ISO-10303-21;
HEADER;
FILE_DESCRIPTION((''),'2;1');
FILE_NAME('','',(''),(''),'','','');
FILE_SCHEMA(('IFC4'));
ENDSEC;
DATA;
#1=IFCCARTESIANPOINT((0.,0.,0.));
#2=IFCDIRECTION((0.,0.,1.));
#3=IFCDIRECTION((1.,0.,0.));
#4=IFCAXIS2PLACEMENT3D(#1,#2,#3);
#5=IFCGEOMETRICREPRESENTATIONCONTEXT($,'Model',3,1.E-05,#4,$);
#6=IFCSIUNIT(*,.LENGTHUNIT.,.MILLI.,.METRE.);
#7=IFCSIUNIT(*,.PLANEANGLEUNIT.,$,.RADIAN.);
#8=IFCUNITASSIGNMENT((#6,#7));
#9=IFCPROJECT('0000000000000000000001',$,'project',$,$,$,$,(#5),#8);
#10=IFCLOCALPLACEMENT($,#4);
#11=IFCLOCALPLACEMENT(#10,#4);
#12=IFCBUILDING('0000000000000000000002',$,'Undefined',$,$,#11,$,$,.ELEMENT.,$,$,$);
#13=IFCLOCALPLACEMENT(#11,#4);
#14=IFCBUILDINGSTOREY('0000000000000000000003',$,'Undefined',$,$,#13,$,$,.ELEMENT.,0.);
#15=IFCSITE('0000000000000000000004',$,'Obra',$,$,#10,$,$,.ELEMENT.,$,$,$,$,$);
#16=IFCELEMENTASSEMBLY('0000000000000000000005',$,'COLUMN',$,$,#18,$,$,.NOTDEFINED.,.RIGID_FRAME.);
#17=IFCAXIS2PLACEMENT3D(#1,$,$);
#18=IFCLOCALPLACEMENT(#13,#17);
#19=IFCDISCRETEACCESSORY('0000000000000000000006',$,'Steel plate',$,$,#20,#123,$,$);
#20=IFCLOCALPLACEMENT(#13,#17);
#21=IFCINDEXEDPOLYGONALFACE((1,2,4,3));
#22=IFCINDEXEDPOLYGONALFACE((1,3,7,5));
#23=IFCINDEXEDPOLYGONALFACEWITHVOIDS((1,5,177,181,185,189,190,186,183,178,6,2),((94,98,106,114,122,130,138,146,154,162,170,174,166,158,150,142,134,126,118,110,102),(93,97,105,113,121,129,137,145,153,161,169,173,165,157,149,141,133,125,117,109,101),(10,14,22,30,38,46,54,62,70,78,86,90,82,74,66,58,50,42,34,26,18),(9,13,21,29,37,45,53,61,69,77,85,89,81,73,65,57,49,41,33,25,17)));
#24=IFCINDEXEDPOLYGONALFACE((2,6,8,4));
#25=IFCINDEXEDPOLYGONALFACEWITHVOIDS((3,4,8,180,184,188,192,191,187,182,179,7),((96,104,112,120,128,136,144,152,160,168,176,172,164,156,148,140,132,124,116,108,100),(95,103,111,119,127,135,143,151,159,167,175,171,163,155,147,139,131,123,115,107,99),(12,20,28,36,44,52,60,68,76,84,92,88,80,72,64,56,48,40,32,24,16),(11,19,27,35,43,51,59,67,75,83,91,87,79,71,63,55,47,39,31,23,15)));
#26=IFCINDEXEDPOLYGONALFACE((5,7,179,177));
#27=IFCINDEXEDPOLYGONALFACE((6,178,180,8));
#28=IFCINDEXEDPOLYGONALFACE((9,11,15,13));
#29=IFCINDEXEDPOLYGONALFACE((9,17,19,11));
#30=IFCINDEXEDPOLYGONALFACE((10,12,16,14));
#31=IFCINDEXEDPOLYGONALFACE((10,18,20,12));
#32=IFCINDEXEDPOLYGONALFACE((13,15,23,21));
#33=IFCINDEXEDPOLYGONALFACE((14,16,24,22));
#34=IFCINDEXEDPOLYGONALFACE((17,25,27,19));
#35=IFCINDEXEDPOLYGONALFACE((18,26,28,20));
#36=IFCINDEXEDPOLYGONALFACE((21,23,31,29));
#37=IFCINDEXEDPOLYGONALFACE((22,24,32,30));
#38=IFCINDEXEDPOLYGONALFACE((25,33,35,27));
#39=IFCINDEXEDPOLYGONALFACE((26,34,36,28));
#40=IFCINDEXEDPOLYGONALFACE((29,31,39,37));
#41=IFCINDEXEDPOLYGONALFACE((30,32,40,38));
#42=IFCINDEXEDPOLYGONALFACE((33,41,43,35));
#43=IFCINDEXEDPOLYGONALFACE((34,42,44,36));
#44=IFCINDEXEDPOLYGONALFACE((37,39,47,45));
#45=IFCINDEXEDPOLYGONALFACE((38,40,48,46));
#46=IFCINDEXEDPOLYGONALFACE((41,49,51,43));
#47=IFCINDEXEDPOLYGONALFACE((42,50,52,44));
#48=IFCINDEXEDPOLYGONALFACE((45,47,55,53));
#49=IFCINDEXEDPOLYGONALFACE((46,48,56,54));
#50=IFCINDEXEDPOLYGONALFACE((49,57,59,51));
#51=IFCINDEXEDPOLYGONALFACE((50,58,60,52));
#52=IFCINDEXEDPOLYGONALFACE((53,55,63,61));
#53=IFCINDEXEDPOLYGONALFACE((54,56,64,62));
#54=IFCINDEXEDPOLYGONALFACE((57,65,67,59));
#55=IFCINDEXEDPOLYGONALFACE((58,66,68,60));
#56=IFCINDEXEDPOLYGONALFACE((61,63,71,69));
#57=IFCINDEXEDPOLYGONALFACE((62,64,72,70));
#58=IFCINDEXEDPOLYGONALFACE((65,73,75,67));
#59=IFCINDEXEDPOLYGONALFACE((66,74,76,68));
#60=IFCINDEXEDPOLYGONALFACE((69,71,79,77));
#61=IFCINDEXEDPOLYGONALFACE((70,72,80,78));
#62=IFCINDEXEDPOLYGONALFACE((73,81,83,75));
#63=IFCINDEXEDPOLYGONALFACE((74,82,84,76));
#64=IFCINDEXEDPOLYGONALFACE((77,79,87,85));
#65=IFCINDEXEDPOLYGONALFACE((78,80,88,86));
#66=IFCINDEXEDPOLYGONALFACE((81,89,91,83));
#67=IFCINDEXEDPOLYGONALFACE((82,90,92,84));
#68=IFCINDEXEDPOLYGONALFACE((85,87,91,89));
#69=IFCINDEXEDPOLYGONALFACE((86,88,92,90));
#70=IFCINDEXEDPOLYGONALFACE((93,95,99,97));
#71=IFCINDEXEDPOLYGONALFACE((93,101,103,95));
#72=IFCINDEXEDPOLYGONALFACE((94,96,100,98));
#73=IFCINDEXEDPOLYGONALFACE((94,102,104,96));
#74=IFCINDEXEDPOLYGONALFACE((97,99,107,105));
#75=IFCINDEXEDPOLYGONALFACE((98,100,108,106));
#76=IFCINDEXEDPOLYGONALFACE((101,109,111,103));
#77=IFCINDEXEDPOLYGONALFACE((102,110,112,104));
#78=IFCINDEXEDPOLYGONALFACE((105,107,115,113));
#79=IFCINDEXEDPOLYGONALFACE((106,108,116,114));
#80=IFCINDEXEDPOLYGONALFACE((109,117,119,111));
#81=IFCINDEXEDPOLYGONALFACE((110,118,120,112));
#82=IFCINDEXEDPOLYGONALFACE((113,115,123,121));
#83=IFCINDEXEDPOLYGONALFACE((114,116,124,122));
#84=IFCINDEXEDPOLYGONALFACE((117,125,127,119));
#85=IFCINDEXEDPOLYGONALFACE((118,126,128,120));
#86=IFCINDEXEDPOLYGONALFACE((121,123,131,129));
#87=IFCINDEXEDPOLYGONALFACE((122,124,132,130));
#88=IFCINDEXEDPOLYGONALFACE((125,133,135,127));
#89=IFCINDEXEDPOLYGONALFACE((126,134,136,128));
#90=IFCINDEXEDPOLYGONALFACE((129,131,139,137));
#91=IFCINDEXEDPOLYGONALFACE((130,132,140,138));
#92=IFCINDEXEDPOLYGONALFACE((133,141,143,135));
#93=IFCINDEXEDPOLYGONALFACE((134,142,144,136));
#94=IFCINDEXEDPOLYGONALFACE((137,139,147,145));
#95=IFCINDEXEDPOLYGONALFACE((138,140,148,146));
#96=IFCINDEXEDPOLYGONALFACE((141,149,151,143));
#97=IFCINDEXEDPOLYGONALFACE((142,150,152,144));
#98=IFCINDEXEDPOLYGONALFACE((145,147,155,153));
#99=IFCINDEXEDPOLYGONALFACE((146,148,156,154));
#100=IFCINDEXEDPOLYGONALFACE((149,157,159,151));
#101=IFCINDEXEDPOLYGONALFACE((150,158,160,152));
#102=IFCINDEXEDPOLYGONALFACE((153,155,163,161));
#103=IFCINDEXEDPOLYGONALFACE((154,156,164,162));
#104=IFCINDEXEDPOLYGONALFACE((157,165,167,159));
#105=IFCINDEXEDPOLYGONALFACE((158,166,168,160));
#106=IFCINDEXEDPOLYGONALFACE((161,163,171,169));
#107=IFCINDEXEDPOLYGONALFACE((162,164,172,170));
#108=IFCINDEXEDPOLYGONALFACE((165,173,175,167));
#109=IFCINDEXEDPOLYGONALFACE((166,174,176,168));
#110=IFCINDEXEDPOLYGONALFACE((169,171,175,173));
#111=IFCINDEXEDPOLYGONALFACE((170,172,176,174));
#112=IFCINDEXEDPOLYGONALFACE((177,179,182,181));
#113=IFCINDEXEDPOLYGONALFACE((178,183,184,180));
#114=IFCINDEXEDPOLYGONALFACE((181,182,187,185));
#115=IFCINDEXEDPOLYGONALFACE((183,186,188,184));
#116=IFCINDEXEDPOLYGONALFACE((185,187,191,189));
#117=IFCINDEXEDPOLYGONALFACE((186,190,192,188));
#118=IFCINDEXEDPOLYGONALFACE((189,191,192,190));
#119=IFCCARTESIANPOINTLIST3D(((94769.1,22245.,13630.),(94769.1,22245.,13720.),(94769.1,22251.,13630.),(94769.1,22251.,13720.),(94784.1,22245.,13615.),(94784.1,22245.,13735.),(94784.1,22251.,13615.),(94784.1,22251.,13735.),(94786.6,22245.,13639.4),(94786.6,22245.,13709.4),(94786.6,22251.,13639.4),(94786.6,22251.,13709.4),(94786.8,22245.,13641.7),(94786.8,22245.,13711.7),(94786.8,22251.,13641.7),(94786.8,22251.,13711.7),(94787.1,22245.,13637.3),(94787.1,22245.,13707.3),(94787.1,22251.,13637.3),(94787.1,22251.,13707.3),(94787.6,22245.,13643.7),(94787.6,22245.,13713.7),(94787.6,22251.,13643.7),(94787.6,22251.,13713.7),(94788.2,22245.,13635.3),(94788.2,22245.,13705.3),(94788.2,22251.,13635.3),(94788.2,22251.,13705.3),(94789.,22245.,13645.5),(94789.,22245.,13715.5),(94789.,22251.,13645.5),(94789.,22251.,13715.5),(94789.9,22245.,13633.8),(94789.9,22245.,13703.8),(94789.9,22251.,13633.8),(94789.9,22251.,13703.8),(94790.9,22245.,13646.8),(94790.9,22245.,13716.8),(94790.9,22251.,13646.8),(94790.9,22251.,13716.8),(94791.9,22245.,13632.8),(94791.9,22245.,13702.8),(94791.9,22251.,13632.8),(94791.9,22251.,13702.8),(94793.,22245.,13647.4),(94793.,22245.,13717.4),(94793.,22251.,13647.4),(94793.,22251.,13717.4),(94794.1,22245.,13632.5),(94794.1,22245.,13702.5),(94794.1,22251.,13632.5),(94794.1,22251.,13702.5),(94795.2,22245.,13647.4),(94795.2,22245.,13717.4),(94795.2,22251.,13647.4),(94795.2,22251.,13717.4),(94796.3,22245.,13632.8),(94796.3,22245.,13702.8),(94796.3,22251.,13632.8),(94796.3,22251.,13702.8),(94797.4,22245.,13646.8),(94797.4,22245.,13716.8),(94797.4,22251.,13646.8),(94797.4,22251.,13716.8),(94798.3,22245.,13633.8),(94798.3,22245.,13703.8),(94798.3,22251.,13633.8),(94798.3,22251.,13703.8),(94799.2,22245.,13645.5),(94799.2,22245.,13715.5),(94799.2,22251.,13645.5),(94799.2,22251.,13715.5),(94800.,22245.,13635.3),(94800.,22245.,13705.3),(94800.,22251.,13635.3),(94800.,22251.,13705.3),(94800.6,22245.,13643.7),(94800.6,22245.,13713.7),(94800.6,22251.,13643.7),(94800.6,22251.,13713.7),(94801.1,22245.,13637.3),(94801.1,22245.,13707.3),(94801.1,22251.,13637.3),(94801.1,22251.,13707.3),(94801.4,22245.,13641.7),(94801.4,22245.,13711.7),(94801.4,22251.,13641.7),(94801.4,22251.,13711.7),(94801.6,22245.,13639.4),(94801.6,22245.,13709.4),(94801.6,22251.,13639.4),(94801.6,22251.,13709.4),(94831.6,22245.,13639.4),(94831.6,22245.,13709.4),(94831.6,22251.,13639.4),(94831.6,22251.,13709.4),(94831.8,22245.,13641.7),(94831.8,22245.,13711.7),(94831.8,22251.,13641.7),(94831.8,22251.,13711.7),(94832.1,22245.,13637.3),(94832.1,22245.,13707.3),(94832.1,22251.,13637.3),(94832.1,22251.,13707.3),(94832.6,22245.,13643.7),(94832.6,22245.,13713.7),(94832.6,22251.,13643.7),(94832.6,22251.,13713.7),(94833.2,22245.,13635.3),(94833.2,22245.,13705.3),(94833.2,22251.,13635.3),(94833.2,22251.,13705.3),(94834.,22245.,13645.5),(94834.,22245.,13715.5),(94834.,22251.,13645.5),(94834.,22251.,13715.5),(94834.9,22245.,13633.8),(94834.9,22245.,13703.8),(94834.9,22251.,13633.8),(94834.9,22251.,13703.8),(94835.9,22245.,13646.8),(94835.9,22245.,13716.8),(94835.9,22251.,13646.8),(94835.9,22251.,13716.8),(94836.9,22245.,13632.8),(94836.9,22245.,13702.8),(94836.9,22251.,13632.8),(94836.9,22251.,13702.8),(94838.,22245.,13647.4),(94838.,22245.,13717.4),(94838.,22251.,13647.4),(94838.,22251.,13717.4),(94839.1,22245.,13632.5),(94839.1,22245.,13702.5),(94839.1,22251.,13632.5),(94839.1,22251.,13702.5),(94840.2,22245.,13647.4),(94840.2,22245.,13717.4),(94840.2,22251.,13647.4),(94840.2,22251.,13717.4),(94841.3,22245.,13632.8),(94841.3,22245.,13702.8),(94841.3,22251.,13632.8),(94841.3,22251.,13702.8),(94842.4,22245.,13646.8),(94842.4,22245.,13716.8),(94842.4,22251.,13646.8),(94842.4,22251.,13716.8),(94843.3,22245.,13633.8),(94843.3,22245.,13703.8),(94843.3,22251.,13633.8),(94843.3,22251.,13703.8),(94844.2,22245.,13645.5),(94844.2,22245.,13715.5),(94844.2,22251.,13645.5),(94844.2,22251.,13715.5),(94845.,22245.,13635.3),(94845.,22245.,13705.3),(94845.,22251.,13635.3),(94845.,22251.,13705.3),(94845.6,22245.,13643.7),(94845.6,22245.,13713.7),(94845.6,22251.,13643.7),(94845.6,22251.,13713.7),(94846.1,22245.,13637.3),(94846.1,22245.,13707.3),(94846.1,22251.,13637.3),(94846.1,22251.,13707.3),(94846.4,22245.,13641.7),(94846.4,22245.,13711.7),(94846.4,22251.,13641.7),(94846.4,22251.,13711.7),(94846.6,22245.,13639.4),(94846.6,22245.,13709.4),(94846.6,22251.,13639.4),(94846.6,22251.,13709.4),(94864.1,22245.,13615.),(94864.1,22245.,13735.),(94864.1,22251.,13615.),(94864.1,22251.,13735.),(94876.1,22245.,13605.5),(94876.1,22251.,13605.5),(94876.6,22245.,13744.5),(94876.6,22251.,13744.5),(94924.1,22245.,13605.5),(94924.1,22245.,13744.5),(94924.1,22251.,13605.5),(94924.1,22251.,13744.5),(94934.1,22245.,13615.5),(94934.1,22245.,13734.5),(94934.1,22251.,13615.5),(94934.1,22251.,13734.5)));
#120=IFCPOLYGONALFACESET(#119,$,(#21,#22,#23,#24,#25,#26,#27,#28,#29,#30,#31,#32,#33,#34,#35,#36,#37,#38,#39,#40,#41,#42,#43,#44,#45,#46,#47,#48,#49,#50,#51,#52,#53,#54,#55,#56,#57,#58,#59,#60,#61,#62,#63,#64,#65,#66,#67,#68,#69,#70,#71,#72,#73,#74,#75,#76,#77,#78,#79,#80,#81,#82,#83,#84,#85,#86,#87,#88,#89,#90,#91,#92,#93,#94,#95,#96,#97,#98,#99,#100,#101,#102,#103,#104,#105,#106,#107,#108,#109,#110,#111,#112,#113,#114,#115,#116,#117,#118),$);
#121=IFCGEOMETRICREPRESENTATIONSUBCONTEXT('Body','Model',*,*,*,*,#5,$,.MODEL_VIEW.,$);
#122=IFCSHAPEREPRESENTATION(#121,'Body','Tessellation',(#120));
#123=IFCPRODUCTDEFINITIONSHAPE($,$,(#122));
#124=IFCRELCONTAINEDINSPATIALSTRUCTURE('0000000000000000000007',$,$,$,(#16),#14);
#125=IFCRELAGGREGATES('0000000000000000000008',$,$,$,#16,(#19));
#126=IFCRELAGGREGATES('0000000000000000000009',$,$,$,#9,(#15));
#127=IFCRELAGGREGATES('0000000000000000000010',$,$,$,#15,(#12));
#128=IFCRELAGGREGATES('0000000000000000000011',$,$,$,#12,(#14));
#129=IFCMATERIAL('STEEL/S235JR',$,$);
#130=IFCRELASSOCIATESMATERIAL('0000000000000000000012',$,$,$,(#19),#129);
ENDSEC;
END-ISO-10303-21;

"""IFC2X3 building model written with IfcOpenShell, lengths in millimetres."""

from ifc_helpers import new_model, si_unit, frame, origin_with_axes, origin_2d_with_axis, place, context, subcontext, project, spatial, polyline, circle, outline, extrude, source, transform, mapped, material, element, aggregate, save


model = new_model("IFC2X3")

# Units and contexts
model_context = context("Model", 3, precision=1e-05, world=origin_with_axes())
body_context = subcontext(model_context, "Body", "Model", "MODEL_VIEW")
ifc_project = project(units=[si_unit("LENGTHUNIT", "METRE", prefix="MILLI"), si_unit("PLANEANGLEUNIT", "RADIAN")], contexts=[model_context])

# Site, building, storey
site_placement = place(None, origin_with_axes())
site = spatial("IfcSite", under=ifc_project, at=site_placement, Name="Obra", CompositionType="ELEMENT")
building_placement = place(site_placement, origin_with_axes())
building = spatial("IfcBuilding", under=site, at=building_placement, Name="Undefined", CompositionType="ELEMENT")
storey_placement = place(building_placement, origin_with_axes())
storey = spatial("IfcBuildingStorey", under=building, at=storey_placement, Name="Undefined", CompositionType="ELEMENT", Elevation=0.0)

# Element assembly, discrete accessory, opening
assembly_placement = place(storey_placement, origin_with_axes())
assembly = element("IfcElementAssembly", 1, at=assembly_placement, inside=storey, Name="COLUMN", AssemblyPlace="NOTDEFINED", PredefinedType="RIGID_FRAME")
ifc_material_1 = material(Name="STEEL/S235JR")
discrete_accessory_1_placement = place(assembly_placement, frame((94934.1, 22248.0, 13615.5), z_axis=(0.0, 1.0, 0.0), x_axis=(-0.707107, 0.0, -0.707107)))
discrete_accessory_1 = element("IfcDiscreteAccessory", 2, at=discrete_accessory_1_placement, material=ifc_material_1, Name="Steel plate", context=body_context, shape_type="SweptSolid", body=[
    extrude(outline(polyline([(0.0, 0.0), (14.1, 0.0), (48.1, 33.9), (49.9, 49.1), (106.4, 105.7), (106.4, 126.9), (42.8, 190.6), (21.6, 190.6), (-35.0, 134.0), (-50.6, 131.9), (-84.1, 98.3), (-84.1, 84.1), (0.0, 0.0)])), frame((0.0, 0.0, -3.0), z_axis=(0.0, 0.0, 1.0), x_axis=(1.0, 0.0, 0.0)), (0.0, 0.0, 1.0), 6.0),
])
shared_shape_1 = source(origin_with_axes(), body_context, "Body", "SweptSolid", [
    extrude(circle(Radius=7.5, at=origin_2d_with_axis()), frame((0.0, 2.4, 0.0), z_axis=(0.0, 1.0, 0.0), x_axis=(1.0, 0.0, 0.0)), (0.0, 0.0, 1.0), 6.2),
])
opening_1_placement = place(assembly_placement, frame((94816.6, 22253.5, 13710.0), z_axis=(-1.0, 0.0, 0.0), x_axis=(0.0, 0.0, -1.0)))
element("IfcOpeningElement", 3, at=opening_1_placement, cuts=discrete_accessory_1, ObjectType="Opening", context=body_context, shape_type="MappedRepresentation", body=[
    mapped(shared_shape_1, transform((0.0, 0.0, -22.5))),
    mapped(shared_shape_1, transform((70.0, 0.0, -22.5))),
    mapped(shared_shape_1, transform((0.0, 0.0, 22.5))),
    mapped(shared_shape_1, transform((70.0, 0.0, 22.5))),
])
aggregate(assembly, [discrete_accessory_1])

save(model, "model.ifc")
